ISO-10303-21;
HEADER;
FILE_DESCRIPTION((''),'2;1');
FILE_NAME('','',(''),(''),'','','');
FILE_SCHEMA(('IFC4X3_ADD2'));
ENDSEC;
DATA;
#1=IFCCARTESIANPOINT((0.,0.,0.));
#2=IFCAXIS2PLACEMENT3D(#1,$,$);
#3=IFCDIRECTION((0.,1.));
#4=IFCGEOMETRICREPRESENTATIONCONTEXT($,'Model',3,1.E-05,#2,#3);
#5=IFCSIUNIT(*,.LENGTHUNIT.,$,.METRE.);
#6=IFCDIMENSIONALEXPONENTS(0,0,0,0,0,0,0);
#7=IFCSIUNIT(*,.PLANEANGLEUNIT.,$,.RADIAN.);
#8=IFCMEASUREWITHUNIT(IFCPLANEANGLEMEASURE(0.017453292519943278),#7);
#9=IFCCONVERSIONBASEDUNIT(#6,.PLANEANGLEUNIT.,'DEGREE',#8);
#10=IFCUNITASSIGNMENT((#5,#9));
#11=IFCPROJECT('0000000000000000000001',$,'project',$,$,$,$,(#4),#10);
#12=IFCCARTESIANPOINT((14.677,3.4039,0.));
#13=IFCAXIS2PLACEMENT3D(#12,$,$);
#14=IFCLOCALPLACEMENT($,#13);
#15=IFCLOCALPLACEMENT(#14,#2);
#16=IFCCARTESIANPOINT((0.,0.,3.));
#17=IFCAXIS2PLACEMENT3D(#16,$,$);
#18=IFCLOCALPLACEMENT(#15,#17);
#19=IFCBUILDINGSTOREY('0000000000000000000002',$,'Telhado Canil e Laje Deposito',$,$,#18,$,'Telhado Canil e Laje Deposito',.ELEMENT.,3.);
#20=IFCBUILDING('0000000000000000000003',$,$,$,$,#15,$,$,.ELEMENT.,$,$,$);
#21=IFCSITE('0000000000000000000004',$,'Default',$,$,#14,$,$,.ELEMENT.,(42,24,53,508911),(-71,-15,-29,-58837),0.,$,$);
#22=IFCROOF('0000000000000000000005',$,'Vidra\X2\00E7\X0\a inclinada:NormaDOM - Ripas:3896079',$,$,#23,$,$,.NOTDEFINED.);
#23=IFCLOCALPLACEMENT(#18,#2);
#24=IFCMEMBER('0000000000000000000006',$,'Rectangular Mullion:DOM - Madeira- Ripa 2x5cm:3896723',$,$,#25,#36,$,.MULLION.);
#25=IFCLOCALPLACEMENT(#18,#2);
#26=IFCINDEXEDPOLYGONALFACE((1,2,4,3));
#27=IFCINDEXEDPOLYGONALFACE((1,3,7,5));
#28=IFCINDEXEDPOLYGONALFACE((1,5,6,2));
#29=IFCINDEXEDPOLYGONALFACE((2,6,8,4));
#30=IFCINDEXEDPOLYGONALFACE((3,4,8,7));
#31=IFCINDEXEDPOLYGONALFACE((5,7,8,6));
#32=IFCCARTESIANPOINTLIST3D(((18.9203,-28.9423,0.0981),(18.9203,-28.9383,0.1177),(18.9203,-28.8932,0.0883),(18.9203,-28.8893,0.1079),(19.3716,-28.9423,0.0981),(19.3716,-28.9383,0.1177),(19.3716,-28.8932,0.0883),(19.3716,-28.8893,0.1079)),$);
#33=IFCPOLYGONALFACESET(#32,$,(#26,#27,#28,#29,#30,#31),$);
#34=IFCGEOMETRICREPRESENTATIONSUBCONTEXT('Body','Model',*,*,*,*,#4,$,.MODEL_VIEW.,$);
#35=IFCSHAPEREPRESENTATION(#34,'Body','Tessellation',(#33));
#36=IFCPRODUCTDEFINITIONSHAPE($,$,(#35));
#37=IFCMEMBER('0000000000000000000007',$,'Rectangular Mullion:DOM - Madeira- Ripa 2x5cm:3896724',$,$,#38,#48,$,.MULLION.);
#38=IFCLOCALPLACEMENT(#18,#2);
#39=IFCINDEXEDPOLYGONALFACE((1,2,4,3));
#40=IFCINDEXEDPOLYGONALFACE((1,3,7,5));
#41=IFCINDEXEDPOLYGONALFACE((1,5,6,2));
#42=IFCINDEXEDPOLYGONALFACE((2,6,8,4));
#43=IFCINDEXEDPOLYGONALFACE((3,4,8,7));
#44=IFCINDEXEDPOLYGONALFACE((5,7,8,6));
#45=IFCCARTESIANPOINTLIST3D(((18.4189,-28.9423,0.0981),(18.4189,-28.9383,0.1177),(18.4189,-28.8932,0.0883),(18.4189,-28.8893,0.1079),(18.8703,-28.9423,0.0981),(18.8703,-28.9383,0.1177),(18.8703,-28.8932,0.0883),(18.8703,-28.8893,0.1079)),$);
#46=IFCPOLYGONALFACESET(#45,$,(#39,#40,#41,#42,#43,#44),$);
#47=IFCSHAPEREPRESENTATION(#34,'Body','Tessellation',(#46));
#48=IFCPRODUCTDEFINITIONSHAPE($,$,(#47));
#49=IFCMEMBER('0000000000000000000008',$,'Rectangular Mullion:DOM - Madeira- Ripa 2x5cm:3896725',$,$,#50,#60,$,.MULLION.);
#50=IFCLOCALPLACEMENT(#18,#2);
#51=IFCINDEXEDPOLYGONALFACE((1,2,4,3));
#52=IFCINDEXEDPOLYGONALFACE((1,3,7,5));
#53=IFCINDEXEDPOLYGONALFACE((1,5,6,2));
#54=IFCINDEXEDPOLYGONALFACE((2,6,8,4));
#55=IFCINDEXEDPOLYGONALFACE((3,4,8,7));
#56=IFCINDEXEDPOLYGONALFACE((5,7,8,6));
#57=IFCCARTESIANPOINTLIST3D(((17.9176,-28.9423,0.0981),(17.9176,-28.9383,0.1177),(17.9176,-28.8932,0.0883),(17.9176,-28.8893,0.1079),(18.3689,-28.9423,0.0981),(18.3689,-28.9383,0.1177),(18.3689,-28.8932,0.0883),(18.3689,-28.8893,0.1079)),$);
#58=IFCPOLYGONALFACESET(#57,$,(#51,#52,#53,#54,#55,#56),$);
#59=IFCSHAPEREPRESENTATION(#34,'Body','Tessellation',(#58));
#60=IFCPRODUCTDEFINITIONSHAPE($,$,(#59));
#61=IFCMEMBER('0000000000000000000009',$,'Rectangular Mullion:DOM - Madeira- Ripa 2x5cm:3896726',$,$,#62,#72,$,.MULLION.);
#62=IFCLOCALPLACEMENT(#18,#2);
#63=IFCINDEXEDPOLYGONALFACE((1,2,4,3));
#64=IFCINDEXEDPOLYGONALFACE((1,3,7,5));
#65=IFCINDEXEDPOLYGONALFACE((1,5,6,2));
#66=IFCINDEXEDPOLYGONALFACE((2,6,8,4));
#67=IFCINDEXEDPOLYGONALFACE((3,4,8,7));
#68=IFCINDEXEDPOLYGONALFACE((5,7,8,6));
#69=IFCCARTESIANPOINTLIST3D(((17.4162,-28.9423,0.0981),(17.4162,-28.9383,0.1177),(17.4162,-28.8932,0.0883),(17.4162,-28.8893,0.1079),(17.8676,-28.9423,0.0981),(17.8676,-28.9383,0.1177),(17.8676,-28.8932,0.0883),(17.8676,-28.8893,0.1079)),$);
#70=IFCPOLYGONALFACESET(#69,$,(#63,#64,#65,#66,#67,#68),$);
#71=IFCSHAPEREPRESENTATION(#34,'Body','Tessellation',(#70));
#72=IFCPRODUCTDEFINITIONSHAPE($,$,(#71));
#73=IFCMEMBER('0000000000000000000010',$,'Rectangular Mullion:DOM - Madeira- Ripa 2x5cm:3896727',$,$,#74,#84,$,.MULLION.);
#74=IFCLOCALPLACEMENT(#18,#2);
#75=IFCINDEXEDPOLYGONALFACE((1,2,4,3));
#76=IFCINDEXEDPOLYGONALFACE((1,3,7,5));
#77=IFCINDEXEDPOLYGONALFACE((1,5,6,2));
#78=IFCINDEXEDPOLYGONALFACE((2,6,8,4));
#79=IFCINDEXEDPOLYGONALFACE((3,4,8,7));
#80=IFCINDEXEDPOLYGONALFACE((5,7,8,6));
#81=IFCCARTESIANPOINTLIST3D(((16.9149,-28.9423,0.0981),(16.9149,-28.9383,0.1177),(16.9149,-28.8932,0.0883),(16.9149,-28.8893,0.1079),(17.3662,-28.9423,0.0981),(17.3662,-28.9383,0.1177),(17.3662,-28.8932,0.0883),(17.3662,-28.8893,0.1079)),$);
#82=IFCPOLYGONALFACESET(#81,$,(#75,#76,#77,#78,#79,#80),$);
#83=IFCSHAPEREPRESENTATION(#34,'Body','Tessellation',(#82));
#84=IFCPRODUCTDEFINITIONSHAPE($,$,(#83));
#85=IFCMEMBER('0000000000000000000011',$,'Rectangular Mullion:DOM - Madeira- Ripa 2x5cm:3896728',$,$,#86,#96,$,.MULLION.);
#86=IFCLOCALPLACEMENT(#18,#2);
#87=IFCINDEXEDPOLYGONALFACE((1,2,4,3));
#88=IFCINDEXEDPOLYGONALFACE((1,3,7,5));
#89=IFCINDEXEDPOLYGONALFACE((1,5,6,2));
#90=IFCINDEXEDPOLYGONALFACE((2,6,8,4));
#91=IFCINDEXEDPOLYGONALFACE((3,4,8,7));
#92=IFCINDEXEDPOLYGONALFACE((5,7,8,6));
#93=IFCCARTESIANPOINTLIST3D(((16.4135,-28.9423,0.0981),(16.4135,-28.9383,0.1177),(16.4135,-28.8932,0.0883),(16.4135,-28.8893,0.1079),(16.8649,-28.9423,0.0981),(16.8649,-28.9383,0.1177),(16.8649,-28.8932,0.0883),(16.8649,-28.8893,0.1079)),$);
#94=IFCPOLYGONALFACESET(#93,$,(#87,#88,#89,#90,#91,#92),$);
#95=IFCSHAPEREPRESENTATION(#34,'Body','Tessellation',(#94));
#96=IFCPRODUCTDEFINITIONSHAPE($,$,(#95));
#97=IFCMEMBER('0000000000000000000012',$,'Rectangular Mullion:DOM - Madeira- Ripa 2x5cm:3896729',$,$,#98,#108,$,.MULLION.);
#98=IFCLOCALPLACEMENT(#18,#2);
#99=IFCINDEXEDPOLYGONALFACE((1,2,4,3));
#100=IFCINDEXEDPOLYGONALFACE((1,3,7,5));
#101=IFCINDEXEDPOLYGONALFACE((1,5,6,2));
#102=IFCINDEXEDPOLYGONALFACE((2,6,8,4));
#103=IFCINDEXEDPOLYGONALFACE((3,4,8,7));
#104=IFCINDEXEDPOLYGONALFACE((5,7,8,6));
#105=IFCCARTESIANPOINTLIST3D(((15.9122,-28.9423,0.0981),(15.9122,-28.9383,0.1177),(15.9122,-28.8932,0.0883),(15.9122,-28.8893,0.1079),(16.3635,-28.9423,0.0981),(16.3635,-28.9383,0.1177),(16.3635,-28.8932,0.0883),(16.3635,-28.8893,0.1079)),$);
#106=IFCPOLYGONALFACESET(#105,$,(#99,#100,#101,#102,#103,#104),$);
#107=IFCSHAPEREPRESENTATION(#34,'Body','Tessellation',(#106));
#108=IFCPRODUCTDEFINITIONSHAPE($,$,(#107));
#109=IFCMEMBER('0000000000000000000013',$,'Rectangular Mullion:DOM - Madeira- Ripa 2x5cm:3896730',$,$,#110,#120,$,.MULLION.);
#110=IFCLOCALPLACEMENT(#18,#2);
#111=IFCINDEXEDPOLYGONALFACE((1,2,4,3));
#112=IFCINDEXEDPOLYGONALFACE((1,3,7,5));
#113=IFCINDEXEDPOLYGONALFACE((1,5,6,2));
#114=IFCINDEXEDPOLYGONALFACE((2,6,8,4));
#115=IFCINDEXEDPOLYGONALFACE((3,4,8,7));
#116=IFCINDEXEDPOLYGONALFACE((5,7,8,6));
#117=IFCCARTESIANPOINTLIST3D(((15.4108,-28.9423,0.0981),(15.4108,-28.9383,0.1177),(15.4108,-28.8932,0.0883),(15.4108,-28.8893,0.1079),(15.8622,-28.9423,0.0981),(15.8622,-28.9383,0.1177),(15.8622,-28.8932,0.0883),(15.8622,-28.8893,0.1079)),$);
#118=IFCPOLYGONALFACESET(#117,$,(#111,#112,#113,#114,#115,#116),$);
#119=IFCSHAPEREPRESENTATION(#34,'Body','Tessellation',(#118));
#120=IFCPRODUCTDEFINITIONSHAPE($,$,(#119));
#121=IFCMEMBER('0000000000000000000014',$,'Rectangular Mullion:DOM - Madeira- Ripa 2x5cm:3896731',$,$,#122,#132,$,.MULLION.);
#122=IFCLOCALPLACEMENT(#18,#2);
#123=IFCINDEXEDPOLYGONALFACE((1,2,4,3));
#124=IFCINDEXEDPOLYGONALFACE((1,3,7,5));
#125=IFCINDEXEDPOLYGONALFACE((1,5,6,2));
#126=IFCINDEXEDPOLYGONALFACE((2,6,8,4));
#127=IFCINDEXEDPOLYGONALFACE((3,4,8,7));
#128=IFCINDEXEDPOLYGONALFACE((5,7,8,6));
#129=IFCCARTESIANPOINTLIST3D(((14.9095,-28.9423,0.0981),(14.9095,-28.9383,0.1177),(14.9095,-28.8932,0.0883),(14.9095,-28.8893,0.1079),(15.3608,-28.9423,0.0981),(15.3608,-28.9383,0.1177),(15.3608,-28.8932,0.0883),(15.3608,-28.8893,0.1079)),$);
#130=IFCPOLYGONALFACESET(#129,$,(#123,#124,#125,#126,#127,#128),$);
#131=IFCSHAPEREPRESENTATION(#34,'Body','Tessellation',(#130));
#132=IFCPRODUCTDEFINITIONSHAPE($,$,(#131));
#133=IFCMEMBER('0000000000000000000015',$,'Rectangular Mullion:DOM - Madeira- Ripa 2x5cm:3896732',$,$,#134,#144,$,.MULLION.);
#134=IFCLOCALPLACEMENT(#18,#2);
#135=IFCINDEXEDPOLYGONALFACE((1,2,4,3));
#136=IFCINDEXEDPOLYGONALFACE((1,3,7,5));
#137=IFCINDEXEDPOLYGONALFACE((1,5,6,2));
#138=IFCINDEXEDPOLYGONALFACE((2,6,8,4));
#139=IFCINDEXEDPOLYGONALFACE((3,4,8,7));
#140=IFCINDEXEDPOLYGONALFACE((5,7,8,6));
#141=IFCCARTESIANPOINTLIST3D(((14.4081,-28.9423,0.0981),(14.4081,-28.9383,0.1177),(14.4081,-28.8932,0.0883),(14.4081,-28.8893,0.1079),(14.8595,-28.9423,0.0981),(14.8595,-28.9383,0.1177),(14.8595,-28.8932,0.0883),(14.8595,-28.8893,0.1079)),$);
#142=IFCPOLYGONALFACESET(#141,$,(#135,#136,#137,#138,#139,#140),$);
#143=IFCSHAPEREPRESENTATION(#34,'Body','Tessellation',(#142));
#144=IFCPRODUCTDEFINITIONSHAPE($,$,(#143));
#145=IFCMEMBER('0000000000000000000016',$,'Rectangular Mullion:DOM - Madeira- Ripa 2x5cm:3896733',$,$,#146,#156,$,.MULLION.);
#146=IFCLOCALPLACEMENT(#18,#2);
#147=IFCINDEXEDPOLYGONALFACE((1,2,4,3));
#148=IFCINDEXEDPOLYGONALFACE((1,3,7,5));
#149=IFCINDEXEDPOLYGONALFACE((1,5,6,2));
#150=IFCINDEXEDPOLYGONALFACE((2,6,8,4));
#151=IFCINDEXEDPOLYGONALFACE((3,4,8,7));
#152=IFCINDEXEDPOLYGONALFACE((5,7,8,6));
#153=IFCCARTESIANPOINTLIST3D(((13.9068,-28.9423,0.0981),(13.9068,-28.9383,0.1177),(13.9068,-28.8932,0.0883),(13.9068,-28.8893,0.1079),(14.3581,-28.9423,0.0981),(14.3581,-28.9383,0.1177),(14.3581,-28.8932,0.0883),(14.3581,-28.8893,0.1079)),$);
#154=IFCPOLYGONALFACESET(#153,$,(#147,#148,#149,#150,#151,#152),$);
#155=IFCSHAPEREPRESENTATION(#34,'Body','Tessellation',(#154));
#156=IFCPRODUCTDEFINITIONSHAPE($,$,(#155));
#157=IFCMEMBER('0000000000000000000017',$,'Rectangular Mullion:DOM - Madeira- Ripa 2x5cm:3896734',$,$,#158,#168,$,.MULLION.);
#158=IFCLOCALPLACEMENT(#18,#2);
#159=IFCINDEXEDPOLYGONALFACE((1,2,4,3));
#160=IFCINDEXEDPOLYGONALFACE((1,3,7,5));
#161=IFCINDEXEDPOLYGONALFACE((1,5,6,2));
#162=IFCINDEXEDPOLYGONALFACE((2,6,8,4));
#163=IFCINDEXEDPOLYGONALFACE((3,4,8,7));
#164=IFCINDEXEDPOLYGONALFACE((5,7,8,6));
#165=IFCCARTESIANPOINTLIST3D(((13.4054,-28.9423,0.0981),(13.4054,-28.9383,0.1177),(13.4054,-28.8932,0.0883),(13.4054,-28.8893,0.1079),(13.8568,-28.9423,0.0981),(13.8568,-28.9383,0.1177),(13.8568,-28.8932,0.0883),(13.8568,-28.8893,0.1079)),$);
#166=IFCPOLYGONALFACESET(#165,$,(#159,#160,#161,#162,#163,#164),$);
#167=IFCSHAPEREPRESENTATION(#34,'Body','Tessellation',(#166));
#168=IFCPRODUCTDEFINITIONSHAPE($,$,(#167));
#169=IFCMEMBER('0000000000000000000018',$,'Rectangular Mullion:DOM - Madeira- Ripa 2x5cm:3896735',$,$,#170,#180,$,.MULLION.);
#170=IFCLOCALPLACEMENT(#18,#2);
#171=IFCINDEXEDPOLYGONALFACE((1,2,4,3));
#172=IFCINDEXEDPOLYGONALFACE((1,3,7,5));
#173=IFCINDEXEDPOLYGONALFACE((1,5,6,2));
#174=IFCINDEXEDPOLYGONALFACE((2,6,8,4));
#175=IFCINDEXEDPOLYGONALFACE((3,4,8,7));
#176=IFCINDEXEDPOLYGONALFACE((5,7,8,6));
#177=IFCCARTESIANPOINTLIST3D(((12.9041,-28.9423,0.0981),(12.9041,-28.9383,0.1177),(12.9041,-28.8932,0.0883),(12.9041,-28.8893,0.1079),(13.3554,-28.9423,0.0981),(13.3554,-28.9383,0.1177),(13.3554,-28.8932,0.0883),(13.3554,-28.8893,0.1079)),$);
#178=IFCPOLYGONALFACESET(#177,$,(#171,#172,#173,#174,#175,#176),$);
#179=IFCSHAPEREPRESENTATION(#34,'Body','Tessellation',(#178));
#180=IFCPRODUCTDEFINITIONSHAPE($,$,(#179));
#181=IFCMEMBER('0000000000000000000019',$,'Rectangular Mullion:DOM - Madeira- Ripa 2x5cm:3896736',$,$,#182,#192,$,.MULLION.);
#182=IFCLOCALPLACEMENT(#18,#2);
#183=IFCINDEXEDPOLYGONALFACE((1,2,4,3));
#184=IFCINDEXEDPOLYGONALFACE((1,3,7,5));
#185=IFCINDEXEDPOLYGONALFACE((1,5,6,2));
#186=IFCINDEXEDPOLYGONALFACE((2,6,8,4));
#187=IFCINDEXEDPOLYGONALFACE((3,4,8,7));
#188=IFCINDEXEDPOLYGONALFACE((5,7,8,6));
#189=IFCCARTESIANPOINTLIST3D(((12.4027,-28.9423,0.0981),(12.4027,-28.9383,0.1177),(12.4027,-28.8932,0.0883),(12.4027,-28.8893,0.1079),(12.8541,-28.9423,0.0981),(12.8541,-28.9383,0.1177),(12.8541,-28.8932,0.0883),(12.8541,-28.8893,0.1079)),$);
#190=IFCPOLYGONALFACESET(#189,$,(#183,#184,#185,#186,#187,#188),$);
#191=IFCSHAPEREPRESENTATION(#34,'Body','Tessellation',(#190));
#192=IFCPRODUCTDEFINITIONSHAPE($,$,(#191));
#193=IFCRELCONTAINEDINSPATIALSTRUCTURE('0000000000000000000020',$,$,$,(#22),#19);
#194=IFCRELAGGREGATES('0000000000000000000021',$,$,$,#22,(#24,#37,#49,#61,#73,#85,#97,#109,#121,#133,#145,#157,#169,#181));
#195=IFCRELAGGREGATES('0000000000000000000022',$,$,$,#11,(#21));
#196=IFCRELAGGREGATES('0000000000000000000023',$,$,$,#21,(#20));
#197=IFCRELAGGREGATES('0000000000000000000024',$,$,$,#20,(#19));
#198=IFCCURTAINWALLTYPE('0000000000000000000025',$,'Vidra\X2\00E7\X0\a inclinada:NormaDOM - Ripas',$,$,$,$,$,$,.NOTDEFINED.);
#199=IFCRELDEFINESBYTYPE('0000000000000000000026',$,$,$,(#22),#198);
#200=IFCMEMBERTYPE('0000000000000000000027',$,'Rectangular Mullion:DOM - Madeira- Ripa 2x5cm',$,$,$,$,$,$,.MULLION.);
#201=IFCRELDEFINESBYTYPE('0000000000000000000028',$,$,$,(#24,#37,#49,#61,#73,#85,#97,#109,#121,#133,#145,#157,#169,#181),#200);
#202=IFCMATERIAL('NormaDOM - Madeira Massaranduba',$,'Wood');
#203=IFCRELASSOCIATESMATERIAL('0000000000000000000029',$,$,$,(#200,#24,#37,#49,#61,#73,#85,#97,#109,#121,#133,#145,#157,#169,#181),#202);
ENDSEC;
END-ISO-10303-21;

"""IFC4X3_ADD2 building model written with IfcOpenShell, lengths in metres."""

from ifc_helpers import new_model, entity, si_unit, converted_unit, direction, frame, origin, origin_2d_with_axis, place, context, subcontext, project, spatial, rectangle, extrude, source, transform, mapped, material, material_profile, profile_set, profile_usage, type_object, type_shapes, element, aggregate, save


model = new_model("IFC4X3_ADD2")

# Units and contexts
model_context = context("Model", 3, precision=1e-05, world=origin(), true_north=direction((0.0, 1.0)))
body_context = subcontext(model_context, "Body", "Model", "MODEL_VIEW")
ifc_project = project(units=[si_unit("LENGTHUNIT", "METRE"), converted_unit("PLANEANGLEUNIT", "DEGREE", entity("IfcPlaneAngleMeasure", 0.017453292519943278), si_unit("PLANEANGLEUNIT", "RADIAN"), dimensions=[0, 0, 0, 0, 0, 0, 0])], contexts=[model_context])

# Site, building, storey
site_placement = place(None, frame((14.677, 3.4039, 0.0)))
site = spatial("IfcSite", under=ifc_project, at=site_placement, Name="Default", CompositionType="ELEMENT", RefLatitude=(42, 24, 53, 508911), RefLongitude=(-71, -15, -29, -58837), RefElevation=0.0)
building_placement = place(site_placement, origin())
building = spatial("IfcBuilding", under=site, at=building_placement, CompositionType="ELEMENT")
storey_placement = place(building_placement, frame((0.0, 0.0, 3.0)))
storey = spatial("IfcBuildingStorey", under=building, at=storey_placement, Name="Telhado Canil e Laje Deposito", LongName="Telhado Canil e Laje Deposito", CompositionType="ELEMENT", Elevation=3.0)

# Roof, members
curtain_wall_type = type_object("IfcCurtainWallType", Name="Vidraça inclinada:NormaDOM - Ripas", PredefinedType="NOTDEFINED")
roof_placement = place(storey_placement, frame((0.0, 0.0, -3.0)))
roof = element("IfcRoof", 1, at=roof_placement, inside=storey, type_object=curtain_wall_type, Name="Vidraça inclinada:NormaDOM - Ripas:3896079", PredefinedType="NOTDEFINED")
ifc_material = material(Name="NormaDOM - Madeira Massaranduba", Category="Wood")
ifc_material_profile_1 = material_profile(ifc_material, rectangle(XDim=0.05, YDim=0.02, at=origin_2d_with_axis()), Name="DOM - Madeira- Ripa 2x5cm")
ifc_profile_set_1 = profile_set([ifc_material_profile_1], Name="DOM - Madeira- Ripa 2x5cm")
ifc_profile_usage_1 = profile_usage(ifc_profile_set_1)
member_type_1 = type_object("IfcMemberType", Name="Rectangular Mullion:DOM - Madeira- Ripa 2x5cm", PredefinedType="MULLION", material=ifc_profile_set_1)
shared_shape_1 = source(origin(), body_context, "Body", "SweptSolid", [
    extrude(rectangle(XDim=0.05, YDim=0.02, at=origin_2d_with_axis()), frame((0.025, 0.01, -0.4514), z_axis=(0.0, 0.0, 1.0), x_axis=(-1.0, 0.0, 0.0)), (0.0, 0.0, 1.0), 0.4514),
])
type_shapes(member_type_1, [shared_shape_1])
member_1_placement = place(roof_placement, frame((19.3716, -28.8893, 3.1079), z_axis=(1.0, 0.0, 0.0), x_axis=(0.0, -0.980581, 0.196116)))
member_1 = element("IfcMember", 2, at=member_1_placement, type_object=member_type_1, material=ifc_profile_usage_1, Name="Rectangular Mullion:DOM - Madeira- Ripa 2x5cm:3896723", PredefinedType="MULLION", context=body_context, shape_type="MappedRepresentation", body=[
    mapped(shared_shape_1, transform((0.0, 0.0, 0.0), scale=1.0)),
])
member_2_placement = place(roof_placement, frame((18.8703, -28.8893, 3.1079), z_axis=(1.0, 0.0, 0.0), x_axis=(0.0, -0.980581, 0.196116)))
member_2 = element("IfcMember", 3, at=member_2_placement, type_object=member_type_1, material=ifc_profile_usage_1, Name="Rectangular Mullion:DOM - Madeira- Ripa 2x5cm:3896724", PredefinedType="MULLION", context=body_context, shape_type="MappedRepresentation", body=[
    mapped(shared_shape_1, transform((0.0, 0.0, 0.0), scale=1.0)),
])
member_3_placement = place(roof_placement, frame((18.3689, -28.8893, 3.1079), z_axis=(1.0, 0.0, 0.0), x_axis=(0.0, -0.980581, 0.196116)))
member_3 = element("IfcMember", 4, at=member_3_placement, type_object=member_type_1, material=ifc_profile_usage_1, Name="Rectangular Mullion:DOM - Madeira- Ripa 2x5cm:3896725", PredefinedType="MULLION", context=body_context, shape_type="MappedRepresentation", body=[
    mapped(shared_shape_1, transform((0.0, 0.0, 0.0), scale=1.0)),
])
member_4_placement = place(roof_placement, frame((17.8676, -28.8893, 3.1079), z_axis=(1.0, 0.0, 0.0), x_axis=(0.0, -0.980581, 0.196116)))
member_4 = element("IfcMember", 5, at=member_4_placement, type_object=member_type_1, material=ifc_profile_usage_1, Name="Rectangular Mullion:DOM - Madeira- Ripa 2x5cm:3896726", PredefinedType="MULLION", context=body_context, shape_type="MappedRepresentation", body=[
    mapped(shared_shape_1, transform((0.0, 0.0, 0.0), scale=1.0)),
])
member_5_placement = place(roof_placement, frame((17.3662, -28.8893, 3.1079), z_axis=(1.0, 0.0, 0.0), x_axis=(0.0, -0.980581, 0.196116)))
member_5 = element("IfcMember", 6, at=member_5_placement, type_object=member_type_1, material=ifc_profile_usage_1, Name="Rectangular Mullion:DOM - Madeira- Ripa 2x5cm:3896727", PredefinedType="MULLION", context=body_context, shape_type="MappedRepresentation", body=[
    mapped(shared_shape_1, transform((0.0, 0.0, 0.0), scale=1.0)),
])
member_6_placement = place(roof_placement, frame((16.8649, -28.8893, 3.1079), z_axis=(1.0, 0.0, 0.0), x_axis=(0.0, -0.980581, 0.196116)))
member_6 = element("IfcMember", 7, at=member_6_placement, type_object=member_type_1, material=ifc_profile_usage_1, Name="Rectangular Mullion:DOM - Madeira- Ripa 2x5cm:3896728", PredefinedType="MULLION", context=body_context, shape_type="MappedRepresentation", body=[
    mapped(shared_shape_1, transform((0.0, 0.0, 0.0), scale=1.0)),
])
member_7_placement = place(roof_placement, frame((16.3635, -28.8893, 3.1079), z_axis=(1.0, 0.0, 0.0), x_axis=(0.0, -0.980581, 0.196116)))
member_7 = element("IfcMember", 8, at=member_7_placement, type_object=member_type_1, material=ifc_profile_usage_1, Name="Rectangular Mullion:DOM - Madeira- Ripa 2x5cm:3896729", PredefinedType="MULLION", context=body_context, shape_type="MappedRepresentation", body=[
    mapped(shared_shape_1, transform((0.0, 0.0, 0.0), scale=1.0)),
])
member_8_placement = place(roof_placement, frame((15.8622, -28.8893, 3.1079), z_axis=(1.0, 0.0, 0.0), x_axis=(0.0, -0.980581, 0.196116)))
member_8 = element("IfcMember", 9, at=member_8_placement, type_object=member_type_1, material=ifc_profile_usage_1, Name="Rectangular Mullion:DOM - Madeira- Ripa 2x5cm:3896730", PredefinedType="MULLION", context=body_context, shape_type="MappedRepresentation", body=[
    mapped(shared_shape_1, transform((0.0, 0.0, 0.0), scale=1.0)),
])
member_9_placement = place(roof_placement, frame((15.3608, -28.8893, 3.1079), z_axis=(1.0, 0.0, 0.0), x_axis=(0.0, -0.980581, 0.196116)))
member_9 = element("IfcMember", 10, at=member_9_placement, type_object=member_type_1, material=ifc_profile_usage_1, Name="Rectangular Mullion:DOM - Madeira- Ripa 2x5cm:3896731", PredefinedType="MULLION", context=body_context, shape_type="MappedRepresentation", body=[
    mapped(shared_shape_1, transform((0.0, 0.0, 0.0), scale=1.0)),
])
member_10_placement = place(roof_placement, frame((14.8595, -28.8893, 3.1079), z_axis=(1.0, 0.0, 0.0), x_axis=(0.0, -0.980581, 0.196116)))
member_10 = element("IfcMember", 11, at=member_10_placement, type_object=member_type_1, material=ifc_profile_usage_1, Name="Rectangular Mullion:DOM - Madeira- Ripa 2x5cm:3896732", PredefinedType="MULLION", context=body_context, shape_type="MappedRepresentation", body=[
    mapped(shared_shape_1, transform((0.0, 0.0, 0.0), scale=1.0)),
])
member_11_placement = place(roof_placement, frame((14.3581, -28.8893, 3.1079), z_axis=(1.0, 0.0, 0.0), x_axis=(0.0, -0.980581, 0.196116)))
member_11 = element("IfcMember", 12, at=member_11_placement, type_object=member_type_1, material=ifc_profile_usage_1, Name="Rectangular Mullion:DOM - Madeira- Ripa 2x5cm:3896733", PredefinedType="MULLION", context=body_context, shape_type="MappedRepresentation", body=[
    mapped(shared_shape_1, transform((0.0, 0.0, 0.0), scale=1.0)),
])
member_12_placement = place(roof_placement, frame((13.8568, -28.8893, 3.1079), z_axis=(1.0, 0.0, 0.0), x_axis=(0.0, -0.980581, 0.196116)))
member_12 = element("IfcMember", 13, at=member_12_placement, type_object=member_type_1, material=ifc_profile_usage_1, Name="Rectangular Mullion:DOM - Madeira- Ripa 2x5cm:3896734", PredefinedType="MULLION", context=body_context, shape_type="MappedRepresentation", body=[
    mapped(shared_shape_1, transform((0.0, 0.0, 0.0), scale=1.0)),
])
member_13_placement = place(roof_placement, frame((13.3554, -28.8893, 3.1079), z_axis=(1.0, 0.0, 0.0), x_axis=(0.0, -0.980581, 0.196116)))
member_13 = element("IfcMember", 14, at=member_13_placement, type_object=member_type_1, material=ifc_profile_usage_1, Name="Rectangular Mullion:DOM - Madeira- Ripa 2x5cm:3896735", PredefinedType="MULLION", context=body_context, shape_type="MappedRepresentation", body=[
    mapped(shared_shape_1, transform((0.0, 0.0, 0.0), scale=1.0)),
])
member_14_placement = place(roof_placement, frame((12.8541, -28.8893, 3.1079), z_axis=(1.0, 0.0, 0.0), x_axis=(0.0, -0.980581, 0.196116)))
member_14 = element("IfcMember", 15, at=member_14_placement, type_object=member_type_1, material=ifc_profile_usage_1, Name="Rectangular Mullion:DOM - Madeira- Ripa 2x5cm:3896736", PredefinedType="MULLION", context=body_context, shape_type="MappedRepresentation", body=[
    mapped(shared_shape_1, transform((0.0, 0.0, 0.0), scale=1.0)),
])
aggregate(roof, [member_1, member_2, member_3, member_4, member_5, member_6, member_7, member_8, member_9, member_10, member_11, member_12, member_13, member_14])

save(model, "model.ifc")
